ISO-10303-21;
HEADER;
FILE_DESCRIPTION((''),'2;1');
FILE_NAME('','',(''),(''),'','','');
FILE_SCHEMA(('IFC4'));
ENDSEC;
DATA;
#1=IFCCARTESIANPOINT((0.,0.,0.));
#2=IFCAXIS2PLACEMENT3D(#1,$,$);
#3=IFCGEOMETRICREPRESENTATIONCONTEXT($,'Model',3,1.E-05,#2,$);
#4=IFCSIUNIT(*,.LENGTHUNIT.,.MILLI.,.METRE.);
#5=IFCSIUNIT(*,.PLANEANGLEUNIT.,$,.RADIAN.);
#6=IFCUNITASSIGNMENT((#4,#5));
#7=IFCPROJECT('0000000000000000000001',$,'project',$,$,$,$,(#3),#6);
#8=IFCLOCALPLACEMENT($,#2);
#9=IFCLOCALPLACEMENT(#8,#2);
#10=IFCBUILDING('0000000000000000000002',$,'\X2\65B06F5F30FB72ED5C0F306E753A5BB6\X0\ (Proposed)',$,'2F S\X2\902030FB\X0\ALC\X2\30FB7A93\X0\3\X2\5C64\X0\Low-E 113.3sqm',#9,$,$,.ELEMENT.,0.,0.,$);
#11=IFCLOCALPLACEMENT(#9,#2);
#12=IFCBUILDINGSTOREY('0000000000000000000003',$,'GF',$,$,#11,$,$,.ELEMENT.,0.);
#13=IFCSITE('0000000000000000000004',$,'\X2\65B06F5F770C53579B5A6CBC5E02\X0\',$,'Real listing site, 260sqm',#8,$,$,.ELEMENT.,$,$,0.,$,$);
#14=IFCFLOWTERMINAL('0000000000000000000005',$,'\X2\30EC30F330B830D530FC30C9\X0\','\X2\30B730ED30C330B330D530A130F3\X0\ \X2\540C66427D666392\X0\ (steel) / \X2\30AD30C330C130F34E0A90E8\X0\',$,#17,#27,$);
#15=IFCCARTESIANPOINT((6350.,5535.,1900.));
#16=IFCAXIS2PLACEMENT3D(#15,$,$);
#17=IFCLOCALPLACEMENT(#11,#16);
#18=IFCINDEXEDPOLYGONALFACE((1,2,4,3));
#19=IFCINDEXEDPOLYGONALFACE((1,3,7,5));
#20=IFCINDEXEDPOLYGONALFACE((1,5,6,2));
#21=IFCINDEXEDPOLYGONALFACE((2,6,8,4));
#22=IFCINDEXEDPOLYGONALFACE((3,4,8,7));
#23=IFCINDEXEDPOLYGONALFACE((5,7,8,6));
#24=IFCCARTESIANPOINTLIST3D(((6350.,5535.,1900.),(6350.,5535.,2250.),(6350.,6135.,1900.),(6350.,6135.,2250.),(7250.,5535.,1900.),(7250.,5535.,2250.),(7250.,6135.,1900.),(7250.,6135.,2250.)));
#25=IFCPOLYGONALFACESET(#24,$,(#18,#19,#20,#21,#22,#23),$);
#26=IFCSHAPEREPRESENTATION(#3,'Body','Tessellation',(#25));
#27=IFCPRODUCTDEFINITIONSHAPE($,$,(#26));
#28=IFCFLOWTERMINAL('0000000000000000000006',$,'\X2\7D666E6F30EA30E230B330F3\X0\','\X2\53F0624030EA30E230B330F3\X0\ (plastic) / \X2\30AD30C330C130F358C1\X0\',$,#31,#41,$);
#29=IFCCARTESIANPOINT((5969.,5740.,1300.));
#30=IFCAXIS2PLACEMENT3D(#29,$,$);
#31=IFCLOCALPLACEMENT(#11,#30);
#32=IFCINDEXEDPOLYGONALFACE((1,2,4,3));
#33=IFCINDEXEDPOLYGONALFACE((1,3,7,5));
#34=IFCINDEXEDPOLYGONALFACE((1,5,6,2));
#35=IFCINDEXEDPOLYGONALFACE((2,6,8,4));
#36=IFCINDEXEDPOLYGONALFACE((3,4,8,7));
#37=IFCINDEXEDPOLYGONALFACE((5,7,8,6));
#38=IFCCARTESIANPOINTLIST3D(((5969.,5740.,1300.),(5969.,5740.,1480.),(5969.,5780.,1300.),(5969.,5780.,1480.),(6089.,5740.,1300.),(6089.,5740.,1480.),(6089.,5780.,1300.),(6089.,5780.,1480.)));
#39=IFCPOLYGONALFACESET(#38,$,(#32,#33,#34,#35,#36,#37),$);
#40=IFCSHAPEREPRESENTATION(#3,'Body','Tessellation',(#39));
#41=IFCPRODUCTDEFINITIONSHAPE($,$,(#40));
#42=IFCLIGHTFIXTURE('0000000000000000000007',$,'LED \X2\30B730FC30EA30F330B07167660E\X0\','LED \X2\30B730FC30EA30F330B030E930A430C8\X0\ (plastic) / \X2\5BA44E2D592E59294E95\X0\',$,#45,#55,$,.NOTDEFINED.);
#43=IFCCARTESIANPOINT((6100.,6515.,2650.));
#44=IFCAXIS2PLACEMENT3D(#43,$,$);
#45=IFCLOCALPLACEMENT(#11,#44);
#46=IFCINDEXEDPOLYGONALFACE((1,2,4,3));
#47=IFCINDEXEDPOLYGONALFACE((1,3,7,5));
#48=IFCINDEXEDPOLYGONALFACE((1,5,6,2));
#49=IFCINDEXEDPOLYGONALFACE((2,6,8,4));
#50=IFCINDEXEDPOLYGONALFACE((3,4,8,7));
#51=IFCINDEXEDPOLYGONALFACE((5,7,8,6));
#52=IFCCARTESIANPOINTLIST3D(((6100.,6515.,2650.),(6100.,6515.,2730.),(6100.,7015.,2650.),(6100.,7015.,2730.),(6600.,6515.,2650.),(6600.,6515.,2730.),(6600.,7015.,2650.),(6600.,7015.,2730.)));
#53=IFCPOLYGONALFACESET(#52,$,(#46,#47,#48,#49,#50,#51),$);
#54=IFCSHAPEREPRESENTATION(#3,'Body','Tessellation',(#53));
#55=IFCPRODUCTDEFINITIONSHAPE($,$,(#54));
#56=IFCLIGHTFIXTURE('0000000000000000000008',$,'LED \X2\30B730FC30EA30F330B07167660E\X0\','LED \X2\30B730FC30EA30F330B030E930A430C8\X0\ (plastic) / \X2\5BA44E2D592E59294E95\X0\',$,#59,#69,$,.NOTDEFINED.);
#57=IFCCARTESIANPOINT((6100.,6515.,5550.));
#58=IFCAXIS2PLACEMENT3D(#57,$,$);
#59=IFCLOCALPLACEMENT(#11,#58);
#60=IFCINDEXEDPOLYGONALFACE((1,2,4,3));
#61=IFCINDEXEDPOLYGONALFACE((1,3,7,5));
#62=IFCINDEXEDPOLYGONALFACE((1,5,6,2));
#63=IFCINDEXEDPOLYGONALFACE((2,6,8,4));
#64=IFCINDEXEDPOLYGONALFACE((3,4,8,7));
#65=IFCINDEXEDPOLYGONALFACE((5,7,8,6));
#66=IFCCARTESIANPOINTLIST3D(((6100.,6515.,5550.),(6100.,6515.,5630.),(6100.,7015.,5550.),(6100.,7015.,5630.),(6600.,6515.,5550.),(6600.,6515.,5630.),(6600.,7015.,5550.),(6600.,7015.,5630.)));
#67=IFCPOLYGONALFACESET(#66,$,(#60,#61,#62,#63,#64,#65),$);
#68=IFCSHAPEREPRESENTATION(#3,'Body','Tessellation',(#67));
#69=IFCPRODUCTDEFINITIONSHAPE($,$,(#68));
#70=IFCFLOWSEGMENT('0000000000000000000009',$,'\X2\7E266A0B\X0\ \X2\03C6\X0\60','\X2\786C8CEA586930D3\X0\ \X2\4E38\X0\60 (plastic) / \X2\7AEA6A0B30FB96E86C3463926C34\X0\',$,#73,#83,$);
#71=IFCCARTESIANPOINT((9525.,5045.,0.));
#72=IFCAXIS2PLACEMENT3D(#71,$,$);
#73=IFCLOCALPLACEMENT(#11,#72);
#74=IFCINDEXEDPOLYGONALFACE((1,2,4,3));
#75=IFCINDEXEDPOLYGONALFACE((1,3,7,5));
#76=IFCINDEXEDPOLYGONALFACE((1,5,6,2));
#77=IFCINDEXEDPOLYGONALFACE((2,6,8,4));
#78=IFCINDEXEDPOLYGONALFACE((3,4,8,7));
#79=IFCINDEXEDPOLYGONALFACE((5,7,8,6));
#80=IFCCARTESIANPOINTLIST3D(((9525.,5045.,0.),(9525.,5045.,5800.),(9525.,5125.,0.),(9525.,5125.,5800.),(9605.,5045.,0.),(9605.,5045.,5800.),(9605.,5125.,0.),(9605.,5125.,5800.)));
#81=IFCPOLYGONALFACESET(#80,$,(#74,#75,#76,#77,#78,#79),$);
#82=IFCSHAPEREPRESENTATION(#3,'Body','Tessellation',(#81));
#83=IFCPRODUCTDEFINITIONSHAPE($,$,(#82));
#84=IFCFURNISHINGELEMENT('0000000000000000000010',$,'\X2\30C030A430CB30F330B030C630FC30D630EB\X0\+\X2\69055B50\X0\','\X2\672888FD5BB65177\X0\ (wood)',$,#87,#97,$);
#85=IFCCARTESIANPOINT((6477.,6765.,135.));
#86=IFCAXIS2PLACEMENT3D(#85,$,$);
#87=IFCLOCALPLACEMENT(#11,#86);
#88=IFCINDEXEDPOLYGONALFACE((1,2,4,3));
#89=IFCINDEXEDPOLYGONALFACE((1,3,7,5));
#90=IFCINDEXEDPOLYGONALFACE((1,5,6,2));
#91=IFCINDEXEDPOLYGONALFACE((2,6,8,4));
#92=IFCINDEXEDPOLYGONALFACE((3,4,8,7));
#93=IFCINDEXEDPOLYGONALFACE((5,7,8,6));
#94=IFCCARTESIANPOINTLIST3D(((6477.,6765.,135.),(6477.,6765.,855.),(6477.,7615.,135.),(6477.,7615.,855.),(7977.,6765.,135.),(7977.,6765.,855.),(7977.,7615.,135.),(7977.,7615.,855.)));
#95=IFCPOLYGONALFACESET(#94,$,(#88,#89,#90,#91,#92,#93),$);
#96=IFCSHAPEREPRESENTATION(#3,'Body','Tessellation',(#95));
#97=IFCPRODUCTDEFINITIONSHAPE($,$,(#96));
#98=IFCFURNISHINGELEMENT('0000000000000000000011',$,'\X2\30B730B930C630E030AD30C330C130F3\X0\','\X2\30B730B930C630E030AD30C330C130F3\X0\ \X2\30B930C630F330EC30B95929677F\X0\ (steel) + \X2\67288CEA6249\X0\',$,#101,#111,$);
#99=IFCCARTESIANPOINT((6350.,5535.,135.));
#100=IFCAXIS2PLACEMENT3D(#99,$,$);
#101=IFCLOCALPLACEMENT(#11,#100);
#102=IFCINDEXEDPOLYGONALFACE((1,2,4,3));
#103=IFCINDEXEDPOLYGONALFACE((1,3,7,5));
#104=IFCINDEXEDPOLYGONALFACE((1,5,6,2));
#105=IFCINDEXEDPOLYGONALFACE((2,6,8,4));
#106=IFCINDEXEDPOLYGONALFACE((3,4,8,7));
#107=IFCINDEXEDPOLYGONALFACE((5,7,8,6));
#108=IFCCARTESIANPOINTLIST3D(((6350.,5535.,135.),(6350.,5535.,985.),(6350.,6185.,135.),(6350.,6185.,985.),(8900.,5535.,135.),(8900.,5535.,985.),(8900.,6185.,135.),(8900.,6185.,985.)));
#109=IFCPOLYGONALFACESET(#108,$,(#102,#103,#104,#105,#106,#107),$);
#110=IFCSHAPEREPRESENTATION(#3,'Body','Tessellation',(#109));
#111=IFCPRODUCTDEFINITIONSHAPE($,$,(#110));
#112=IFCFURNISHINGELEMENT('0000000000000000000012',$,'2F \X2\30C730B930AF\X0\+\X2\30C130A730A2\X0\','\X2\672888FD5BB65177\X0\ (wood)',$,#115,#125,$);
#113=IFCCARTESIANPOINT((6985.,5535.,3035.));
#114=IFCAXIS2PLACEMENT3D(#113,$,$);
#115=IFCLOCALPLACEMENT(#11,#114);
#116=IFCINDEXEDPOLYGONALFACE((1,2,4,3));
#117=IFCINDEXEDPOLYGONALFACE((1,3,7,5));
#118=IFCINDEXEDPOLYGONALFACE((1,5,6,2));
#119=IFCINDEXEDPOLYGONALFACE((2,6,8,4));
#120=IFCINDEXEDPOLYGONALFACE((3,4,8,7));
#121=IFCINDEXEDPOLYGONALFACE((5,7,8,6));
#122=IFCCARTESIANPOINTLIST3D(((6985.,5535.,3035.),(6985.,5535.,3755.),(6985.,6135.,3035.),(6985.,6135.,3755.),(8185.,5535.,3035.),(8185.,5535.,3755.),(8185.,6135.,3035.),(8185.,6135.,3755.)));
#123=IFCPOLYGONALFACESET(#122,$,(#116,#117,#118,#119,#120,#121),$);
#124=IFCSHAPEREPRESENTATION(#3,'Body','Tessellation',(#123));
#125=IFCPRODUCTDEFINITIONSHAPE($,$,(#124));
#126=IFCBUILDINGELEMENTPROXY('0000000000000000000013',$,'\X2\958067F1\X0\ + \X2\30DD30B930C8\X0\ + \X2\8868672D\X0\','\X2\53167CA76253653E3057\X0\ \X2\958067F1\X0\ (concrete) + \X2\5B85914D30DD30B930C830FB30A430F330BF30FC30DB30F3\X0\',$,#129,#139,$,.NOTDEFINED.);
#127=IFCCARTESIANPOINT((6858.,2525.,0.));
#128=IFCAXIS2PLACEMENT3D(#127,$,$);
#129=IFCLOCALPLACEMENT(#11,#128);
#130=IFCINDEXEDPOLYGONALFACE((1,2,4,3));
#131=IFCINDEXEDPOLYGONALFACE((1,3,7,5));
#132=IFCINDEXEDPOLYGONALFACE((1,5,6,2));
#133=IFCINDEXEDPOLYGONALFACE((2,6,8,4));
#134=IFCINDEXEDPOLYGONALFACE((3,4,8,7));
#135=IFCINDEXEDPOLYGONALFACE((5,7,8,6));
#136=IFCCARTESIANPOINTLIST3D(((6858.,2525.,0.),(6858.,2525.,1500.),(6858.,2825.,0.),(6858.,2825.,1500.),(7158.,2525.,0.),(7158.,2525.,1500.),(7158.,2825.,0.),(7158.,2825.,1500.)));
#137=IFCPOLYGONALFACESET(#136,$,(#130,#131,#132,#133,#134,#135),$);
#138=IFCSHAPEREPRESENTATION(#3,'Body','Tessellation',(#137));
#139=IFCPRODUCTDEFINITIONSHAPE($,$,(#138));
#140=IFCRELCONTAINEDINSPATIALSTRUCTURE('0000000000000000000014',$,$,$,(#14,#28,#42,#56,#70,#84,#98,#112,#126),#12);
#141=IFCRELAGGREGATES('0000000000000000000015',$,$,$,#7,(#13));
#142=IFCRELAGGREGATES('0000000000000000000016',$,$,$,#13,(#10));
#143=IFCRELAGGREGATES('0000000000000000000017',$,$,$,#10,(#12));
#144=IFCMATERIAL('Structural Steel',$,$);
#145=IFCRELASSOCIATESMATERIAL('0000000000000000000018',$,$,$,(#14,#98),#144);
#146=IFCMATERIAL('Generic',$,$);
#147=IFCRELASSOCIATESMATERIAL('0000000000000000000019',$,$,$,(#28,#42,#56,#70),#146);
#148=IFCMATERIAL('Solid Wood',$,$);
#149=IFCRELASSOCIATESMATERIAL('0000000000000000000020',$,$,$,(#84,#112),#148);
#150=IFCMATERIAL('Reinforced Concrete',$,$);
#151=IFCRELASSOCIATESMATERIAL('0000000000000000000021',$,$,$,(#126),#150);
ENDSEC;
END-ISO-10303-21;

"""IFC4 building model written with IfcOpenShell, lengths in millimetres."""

from ifc_helpers import new_model, si_unit, frame, frame_2d, origin, place, context, project, spatial, rectangle, extrude, material, element, save


model = new_model("IFC4")

# Units and contexts
model_context = context("Model", 3, precision=1e-05, world=origin())
ifc_project = project(units=[si_unit("LENGTHUNIT", "METRE", prefix="MILLI"), si_unit("PLANEANGLEUNIT", "RADIAN")], contexts=[model_context])

# Site, building, storey
site_placement = place(None, origin())
site = spatial("IfcSite", under=ifc_project, at=site_placement, Name="新潟県南魚沼市", ObjectType="Real listing site, 260sqm", CompositionType="ELEMENT", RefElevation=0.0)
building_placement = place(site_placement, origin())
building = spatial("IfcBuilding", under=site, at=building_placement, Name="新潟・狭小の町家 (Proposed)", ObjectType="2F S造・ALC・窓3層Low-E 113.3sqm", CompositionType="ELEMENT", ElevationOfRefHeight=0.0, ElevationOfTerrain=0.0)
storey_placement = place(building_placement, origin())
storey = spatial("IfcBuildingStorey", under=building, at=storey_placement, Name="GF", CompositionType="ELEMENT", Elevation=0.0)

# Shared definitions
ifc_material_1 = material(Name="Solid Wood")

# Shared definitions
ifc_material_2 = material(Name="Reinforced Concrete")

# Shared definitions
ifc_material_3 = material(Name="Structural Steel")

# Flow terminals
flow_terminal_1_placement = place(storey_placement, frame((6350.0, 5535.0, 1900.0)))
element("IfcFlowTerminal", 1, at=flow_terminal_1_placement, inside=storey, material=ifc_material_3, Name="レンジフード", Description="シロッコファン 同時給排 (steel) / キッチン上部", context=model_context, shape_type="SweptSolid", body=[
    extrude(rectangle(XDim=900.0, YDim=600.0, at=frame_2d((450.0, 300.0))), frame((6350.0, 5535.0, 1900.0)), (0.0, 0.0, 1.0), 350.0),
])
ifc_material_4 = material(Name="Generic")
flow_terminal_2_placement = place(storey_placement, frame((5969.0, 5740.0, 1300.0)))
element("IfcFlowTerminal", 2, at=flow_terminal_2_placement, inside=storey, material=ifc_material_4, Name="給湯リモコン", Description="台所リモコン (plastic) / キッチン壁", context=model_context, shape_type="SweptSolid", body=[
    extrude(rectangle(XDim=120.0, YDim=40.0, at=frame_2d((60.0, 20.0))), frame((5969.0, 5740.0, 1300.0)), (0.0, 0.0, 1.0), 180.0),
])

# Light fixtures
light_fixture_1_placement = place(storey_placement, frame((6100.0, 6515.0, 2650.0)))
element("IfcLightFixture", 3, at=light_fixture_1_placement, inside=storey, material=ifc_material_4, Name="LED シーリング照明", Description="LED シーリングライト (plastic) / 室中央天井", PredefinedType="NOTDEFINED", context=model_context, shape_type="SweptSolid", body=[
    extrude(rectangle(XDim=500.0, YDim=500.0, at=frame_2d((250.0, 250.0))), frame((6100.0, 6515.0, 2650.0)), (0.0, 0.0, 1.0), 80.0),
])
light_fixture_2_placement = place(storey_placement, frame((6100.0, 6515.0, 5550.0)))
element("IfcLightFixture", 4, at=light_fixture_2_placement, inside=storey, material=ifc_material_4, Name="LED シーリング照明", Description="LED シーリングライト (plastic) / 室中央天井", PredefinedType="NOTDEFINED", context=model_context, shape_type="SweptSolid", body=[
    extrude(rectangle(XDim=500.0, YDim=500.0, at=frame_2d((250.0, 250.0))), frame((6100.0, 6515.0, 5550.0)), (0.0, 0.0, 1.0), 80.0),
])

# Flow segment
flow_segment_placement = place(storey_placement, frame((9525.0, 5045.0, 0.0)))
element("IfcFlowSegment", 5, at=flow_segment_placement, inside=storey, material=ifc_material_4, Name="縦樋 φ60", Description="硬質塩ビ 丸60 (plastic) / 竪樋・雨水排水", context=model_context, shape_type="SweptSolid", body=[
    extrude(rectangle(XDim=80.0, YDim=80.0, at=frame_2d((40.0, 40.0))), frame((9525.0, 5045.0, 0.0)), (0.0, 0.0, 1.0), 5800.0),
])

# Furnishing elements
furnishing_1_placement = place(storey_placement, frame((6477.0, 6765.0, 135.0)))
element("IfcFurnishingElement", 6, at=furnishing_1_placement, inside=storey, material=ifc_material_1, Name="ダイニングテーブル+椅子", Description="木製家具 (wood)", context=model_context, shape_type="SweptSolid", body=[
    extrude(rectangle(XDim=1500.0, YDim=850.0, at=frame_2d((750.0, 425.0))), frame((6477.0, 6765.0, 135.0)), (0.0, 0.0, 1.0), 720.0),
])
furnishing_2_placement = place(storey_placement, frame((6350.0, 5535.0, 135.0)))
element("IfcFurnishingElement", 7, at=furnishing_2_placement, inside=storey, material=ifc_material_3, Name="システムキッチン", Description="システムキッチン ステンレス天板 (steel) + 木質扉", context=model_context, shape_type="SweptSolid", body=[
    extrude(rectangle(XDim=2550.0, YDim=650.0, at=frame_2d((1275.0, 325.0))), frame((6350.0, 5535.0, 135.0)), (0.0, 0.0, 1.0), 850.0),
])
furnishing_3_placement = place(storey_placement, frame((6985.0, 5535.0, 3035.0)))
element("IfcFurnishingElement", 8, at=furnishing_3_placement, inside=storey, material=ifc_material_1, Name="2F デスク+チェア", Description="木製家具 (wood)", context=model_context, shape_type="SweptSolid", body=[
    extrude(rectangle(XDim=1200.0, YDim=600.0, at=frame_2d((600.0, 300.0))), frame((6985.0, 5535.0, 3035.0)), (0.0, 0.0, 1.0), 720.0),
])

# Building element proxy
proxy_placement = place(storey_placement, frame((6858.0, 2525.0, 0.0)))
element("IfcBuildingElementProxy", 9, at=proxy_placement, inside=storey, material=ifc_material_2, Name="門柱 + ポスト + 表札", Description="化粧打放し 門柱 (concrete) + 宅配ポスト・インターホン", PredefinedType="NOTDEFINED", context=model_context, shape_type="SweptSolid", body=[
    extrude(rectangle(XDim=300.0, YDim=300.0, at=frame_2d((150.0, 150.0))), frame((6858.0, 2525.0, 0.0)), (0.0, 0.0, 1.0), 1500.0),
])

save(model, "model.ifc")
